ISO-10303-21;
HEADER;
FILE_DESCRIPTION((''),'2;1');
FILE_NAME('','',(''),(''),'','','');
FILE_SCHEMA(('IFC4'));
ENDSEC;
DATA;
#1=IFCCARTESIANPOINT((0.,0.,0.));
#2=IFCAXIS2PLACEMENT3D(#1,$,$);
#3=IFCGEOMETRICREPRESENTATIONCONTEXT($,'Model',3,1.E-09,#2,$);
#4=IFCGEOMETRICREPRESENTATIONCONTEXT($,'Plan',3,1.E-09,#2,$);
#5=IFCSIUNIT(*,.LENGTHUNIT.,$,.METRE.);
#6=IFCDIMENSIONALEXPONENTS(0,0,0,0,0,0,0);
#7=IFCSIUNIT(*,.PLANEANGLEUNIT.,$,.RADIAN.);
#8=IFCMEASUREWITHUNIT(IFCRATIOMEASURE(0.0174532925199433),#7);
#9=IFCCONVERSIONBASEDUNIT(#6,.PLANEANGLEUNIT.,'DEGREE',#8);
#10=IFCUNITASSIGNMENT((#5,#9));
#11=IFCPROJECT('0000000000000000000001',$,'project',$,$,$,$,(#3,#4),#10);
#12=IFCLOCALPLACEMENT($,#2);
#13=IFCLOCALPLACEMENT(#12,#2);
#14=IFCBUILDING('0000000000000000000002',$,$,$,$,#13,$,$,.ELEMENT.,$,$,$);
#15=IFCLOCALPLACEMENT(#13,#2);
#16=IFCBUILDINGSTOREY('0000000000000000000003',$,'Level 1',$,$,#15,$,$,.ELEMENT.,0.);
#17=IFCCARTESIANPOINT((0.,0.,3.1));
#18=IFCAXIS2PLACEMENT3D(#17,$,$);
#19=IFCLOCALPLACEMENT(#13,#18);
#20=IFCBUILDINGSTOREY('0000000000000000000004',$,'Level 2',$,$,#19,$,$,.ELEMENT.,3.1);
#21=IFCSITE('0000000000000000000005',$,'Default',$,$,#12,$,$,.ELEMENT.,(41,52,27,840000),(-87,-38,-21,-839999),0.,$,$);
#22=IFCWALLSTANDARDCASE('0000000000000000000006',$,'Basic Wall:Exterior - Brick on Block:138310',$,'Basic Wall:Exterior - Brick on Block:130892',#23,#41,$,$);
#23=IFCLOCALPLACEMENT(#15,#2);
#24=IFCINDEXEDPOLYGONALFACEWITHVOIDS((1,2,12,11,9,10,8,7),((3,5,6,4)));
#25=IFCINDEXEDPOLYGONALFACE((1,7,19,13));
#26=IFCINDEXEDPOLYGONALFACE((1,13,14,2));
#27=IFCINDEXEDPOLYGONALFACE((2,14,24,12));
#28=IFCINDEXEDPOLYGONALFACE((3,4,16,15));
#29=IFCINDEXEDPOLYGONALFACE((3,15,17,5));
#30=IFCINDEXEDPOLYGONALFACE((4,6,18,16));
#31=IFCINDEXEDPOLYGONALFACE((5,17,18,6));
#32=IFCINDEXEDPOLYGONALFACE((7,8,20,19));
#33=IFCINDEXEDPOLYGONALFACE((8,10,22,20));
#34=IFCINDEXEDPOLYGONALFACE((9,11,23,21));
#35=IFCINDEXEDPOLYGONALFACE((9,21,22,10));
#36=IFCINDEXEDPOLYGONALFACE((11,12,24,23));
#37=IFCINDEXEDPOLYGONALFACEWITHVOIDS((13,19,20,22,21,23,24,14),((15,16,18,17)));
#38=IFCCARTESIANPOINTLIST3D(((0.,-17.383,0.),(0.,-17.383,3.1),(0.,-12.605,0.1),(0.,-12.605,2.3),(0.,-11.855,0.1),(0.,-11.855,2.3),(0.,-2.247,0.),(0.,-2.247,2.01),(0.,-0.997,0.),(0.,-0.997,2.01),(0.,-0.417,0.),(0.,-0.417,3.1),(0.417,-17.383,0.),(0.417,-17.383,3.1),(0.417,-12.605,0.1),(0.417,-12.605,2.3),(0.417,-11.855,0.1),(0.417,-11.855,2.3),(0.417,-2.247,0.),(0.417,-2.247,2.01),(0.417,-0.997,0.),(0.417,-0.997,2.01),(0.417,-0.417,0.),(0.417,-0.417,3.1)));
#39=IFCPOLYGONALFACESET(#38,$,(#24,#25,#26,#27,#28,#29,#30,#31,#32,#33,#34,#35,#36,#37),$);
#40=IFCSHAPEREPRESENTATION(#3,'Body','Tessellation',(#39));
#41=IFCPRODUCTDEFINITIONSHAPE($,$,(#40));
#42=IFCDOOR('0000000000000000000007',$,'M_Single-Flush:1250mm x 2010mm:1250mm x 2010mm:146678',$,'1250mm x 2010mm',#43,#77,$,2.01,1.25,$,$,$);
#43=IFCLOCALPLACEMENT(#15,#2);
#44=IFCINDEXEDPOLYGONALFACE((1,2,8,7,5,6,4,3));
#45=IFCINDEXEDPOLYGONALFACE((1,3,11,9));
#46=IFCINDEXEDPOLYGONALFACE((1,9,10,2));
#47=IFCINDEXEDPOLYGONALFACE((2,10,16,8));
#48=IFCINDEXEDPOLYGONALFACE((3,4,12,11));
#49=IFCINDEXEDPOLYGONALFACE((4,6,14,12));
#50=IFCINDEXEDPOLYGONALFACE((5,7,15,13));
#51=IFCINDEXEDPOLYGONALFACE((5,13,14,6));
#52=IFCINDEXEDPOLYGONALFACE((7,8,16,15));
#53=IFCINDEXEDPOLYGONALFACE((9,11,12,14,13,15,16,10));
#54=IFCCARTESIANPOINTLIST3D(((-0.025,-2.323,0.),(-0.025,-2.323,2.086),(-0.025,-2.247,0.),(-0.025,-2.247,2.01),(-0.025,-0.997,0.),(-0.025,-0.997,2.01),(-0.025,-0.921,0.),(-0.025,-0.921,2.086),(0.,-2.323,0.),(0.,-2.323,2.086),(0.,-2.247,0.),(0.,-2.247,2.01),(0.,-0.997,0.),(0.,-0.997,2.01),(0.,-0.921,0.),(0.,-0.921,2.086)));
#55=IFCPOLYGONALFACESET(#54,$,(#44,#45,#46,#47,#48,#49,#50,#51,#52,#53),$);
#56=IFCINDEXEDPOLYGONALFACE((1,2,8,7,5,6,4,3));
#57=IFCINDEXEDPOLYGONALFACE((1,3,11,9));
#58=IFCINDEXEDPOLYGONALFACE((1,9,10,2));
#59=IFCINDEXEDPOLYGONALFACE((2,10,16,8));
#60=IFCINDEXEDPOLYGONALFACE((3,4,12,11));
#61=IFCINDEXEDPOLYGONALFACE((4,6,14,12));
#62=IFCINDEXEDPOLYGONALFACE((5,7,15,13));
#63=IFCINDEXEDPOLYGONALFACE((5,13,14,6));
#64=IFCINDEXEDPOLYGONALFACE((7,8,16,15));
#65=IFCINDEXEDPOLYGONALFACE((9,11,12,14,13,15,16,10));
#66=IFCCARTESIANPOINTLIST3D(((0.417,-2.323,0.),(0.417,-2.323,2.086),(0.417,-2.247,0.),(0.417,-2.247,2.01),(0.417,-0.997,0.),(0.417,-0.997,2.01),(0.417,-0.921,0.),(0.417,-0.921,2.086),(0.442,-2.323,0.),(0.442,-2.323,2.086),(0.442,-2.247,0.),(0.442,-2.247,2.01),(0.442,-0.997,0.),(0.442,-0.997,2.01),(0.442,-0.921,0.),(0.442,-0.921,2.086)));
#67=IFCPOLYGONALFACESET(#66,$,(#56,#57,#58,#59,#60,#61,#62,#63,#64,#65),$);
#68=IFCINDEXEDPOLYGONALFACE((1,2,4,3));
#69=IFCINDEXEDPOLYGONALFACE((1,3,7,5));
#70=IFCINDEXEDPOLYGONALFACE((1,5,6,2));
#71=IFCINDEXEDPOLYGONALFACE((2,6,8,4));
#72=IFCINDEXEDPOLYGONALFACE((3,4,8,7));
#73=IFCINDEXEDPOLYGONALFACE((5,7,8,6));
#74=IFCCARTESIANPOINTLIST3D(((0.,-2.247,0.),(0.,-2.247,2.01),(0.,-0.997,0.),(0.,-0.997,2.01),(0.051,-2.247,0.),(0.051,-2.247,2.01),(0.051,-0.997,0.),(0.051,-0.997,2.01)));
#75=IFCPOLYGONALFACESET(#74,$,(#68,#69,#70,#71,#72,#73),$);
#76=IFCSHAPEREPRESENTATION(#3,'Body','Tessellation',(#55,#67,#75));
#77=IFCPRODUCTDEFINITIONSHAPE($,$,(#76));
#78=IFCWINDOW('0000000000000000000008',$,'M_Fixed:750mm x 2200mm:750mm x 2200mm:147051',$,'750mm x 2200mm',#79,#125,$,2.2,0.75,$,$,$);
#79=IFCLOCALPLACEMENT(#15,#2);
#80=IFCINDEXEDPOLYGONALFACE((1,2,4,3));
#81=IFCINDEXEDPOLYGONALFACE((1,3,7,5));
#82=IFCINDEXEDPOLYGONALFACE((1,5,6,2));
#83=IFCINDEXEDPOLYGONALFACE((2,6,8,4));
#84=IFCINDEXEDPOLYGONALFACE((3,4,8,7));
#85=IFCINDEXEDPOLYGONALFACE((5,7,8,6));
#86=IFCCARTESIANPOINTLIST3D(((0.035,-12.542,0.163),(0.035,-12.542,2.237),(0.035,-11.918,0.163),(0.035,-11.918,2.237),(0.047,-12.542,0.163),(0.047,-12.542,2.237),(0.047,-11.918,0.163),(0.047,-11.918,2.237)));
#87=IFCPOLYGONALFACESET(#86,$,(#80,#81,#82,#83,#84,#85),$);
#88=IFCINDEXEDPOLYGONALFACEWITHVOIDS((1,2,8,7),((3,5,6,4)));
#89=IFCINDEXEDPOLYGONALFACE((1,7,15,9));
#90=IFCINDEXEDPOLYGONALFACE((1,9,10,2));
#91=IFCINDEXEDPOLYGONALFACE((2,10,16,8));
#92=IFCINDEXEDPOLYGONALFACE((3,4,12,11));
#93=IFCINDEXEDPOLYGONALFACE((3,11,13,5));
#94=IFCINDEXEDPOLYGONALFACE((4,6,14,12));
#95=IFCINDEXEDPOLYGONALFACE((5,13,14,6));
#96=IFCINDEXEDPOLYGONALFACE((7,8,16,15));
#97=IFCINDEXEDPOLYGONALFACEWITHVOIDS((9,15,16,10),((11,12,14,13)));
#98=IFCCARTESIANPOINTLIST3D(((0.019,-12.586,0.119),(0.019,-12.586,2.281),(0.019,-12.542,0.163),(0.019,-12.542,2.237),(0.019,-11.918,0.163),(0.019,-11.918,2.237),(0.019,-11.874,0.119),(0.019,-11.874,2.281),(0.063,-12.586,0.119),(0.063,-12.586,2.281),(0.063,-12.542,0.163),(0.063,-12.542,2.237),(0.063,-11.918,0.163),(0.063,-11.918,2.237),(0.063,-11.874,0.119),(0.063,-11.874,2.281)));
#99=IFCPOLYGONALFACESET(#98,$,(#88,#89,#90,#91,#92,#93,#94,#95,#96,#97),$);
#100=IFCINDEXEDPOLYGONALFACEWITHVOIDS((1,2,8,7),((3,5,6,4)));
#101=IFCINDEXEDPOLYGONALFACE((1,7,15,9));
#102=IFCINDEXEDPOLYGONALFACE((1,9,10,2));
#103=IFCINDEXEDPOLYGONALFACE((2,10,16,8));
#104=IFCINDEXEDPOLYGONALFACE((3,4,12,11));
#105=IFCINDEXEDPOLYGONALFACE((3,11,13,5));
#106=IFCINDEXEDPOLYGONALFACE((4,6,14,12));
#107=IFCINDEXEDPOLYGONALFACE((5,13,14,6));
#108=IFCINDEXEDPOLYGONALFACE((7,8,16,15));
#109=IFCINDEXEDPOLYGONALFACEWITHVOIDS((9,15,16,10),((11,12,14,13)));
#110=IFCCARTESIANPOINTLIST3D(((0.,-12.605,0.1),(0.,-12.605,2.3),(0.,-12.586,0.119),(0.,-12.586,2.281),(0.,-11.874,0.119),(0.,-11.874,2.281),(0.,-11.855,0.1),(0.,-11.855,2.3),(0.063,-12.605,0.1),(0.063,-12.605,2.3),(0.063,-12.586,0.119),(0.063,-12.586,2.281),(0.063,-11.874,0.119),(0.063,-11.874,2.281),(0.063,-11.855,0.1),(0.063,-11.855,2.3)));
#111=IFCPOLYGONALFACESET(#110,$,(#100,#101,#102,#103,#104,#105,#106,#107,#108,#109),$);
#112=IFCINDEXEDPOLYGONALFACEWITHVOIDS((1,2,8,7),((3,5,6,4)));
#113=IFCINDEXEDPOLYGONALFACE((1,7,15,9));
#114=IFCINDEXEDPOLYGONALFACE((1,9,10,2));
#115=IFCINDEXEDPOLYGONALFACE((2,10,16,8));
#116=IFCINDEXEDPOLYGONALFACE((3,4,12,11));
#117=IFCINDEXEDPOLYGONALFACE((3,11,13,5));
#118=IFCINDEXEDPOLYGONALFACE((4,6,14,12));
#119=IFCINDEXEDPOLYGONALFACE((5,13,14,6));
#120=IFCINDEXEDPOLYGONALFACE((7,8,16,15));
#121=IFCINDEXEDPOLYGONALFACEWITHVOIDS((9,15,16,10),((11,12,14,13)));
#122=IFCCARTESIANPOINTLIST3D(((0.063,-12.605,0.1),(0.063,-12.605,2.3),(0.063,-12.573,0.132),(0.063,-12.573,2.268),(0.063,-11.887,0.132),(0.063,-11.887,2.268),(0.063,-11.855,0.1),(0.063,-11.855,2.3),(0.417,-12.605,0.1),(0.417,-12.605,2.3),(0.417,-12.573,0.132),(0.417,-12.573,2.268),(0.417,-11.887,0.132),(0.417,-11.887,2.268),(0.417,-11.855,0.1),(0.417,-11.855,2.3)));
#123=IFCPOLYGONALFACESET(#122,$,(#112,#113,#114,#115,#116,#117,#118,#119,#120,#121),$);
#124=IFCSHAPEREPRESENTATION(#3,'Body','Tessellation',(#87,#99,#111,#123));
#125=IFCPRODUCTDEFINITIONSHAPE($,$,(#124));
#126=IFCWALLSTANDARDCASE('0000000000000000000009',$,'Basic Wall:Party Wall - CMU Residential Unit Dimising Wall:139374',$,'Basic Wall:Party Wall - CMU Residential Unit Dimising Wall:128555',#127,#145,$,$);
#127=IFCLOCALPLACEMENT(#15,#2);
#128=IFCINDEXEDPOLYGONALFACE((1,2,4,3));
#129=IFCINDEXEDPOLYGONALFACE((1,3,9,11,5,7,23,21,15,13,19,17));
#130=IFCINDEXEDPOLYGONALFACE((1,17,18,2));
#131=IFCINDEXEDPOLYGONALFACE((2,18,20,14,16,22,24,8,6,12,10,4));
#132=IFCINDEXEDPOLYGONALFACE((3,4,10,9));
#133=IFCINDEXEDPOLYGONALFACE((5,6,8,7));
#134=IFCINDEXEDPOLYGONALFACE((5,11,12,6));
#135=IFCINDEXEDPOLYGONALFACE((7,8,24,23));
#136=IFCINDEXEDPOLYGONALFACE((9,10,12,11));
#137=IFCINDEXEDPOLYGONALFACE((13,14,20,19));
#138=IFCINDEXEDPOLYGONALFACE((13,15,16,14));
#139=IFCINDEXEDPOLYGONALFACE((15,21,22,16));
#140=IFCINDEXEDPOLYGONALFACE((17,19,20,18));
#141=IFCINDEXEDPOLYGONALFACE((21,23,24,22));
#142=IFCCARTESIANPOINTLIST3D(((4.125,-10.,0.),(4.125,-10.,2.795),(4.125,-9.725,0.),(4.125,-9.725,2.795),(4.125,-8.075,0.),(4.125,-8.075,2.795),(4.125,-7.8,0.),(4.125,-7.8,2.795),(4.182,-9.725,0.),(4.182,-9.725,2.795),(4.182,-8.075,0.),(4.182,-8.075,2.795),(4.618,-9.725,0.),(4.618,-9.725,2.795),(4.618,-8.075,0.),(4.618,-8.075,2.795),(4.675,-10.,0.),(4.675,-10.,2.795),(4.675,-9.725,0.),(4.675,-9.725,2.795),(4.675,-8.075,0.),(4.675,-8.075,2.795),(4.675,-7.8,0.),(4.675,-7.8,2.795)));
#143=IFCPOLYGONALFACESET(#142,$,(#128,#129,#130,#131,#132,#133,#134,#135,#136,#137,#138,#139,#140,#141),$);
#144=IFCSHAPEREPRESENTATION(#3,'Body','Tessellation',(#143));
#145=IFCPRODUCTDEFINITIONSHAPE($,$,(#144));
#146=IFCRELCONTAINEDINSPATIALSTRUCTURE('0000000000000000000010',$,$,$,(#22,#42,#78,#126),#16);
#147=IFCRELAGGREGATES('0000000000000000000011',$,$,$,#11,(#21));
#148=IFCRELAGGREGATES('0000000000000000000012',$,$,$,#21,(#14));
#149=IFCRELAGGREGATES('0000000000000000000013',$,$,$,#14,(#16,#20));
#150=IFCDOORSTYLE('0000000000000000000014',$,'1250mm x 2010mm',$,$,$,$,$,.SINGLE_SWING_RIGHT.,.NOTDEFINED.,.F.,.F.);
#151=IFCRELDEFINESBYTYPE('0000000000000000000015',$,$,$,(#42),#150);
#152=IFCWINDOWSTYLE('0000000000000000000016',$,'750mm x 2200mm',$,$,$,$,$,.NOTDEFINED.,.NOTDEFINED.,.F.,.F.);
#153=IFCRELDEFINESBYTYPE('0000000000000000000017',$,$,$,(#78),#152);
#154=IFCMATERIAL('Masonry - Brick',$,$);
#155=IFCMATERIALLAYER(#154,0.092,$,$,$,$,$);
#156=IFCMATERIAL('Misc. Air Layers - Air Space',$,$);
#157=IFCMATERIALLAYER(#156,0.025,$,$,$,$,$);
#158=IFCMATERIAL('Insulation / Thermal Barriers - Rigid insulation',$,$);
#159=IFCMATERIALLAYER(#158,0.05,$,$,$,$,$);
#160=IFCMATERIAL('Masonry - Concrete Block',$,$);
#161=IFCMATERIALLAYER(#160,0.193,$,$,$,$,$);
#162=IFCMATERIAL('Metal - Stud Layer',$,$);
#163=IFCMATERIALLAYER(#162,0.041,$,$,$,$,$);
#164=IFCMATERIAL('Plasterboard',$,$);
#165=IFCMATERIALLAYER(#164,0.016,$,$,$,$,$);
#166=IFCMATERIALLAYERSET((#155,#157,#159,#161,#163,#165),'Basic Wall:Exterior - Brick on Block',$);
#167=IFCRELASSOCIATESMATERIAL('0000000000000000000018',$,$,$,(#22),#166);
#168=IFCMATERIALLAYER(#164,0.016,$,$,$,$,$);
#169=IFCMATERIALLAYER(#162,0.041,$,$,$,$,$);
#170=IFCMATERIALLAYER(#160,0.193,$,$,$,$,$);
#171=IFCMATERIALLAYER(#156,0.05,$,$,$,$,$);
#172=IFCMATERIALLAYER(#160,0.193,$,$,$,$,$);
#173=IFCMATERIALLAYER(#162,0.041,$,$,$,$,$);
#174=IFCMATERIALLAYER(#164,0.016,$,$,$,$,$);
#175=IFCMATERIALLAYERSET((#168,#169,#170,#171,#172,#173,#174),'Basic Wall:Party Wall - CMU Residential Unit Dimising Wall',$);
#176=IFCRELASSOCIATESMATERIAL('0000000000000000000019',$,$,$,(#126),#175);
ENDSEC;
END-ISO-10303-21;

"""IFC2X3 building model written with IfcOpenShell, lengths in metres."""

from ifc_helpers import new_model, entity, si_unit, converted_unit, frame, frame_2d, origin, origin_2d_with_axis, place, context, project, spatial, polyline, rectangle, outline, extrude, clip, bounded_halfspace, source, transform, mapped, material, layer, layer_set, layer_usage, type_object, type_shapes, element, fill, save


model = new_model("IFC2X3")

# Units and contexts
model_context = context("Model", 3, precision=1e-09, world=origin())
plan_context = context("Plan", 3, precision=1e-09, world=origin())
ifc_project = project(units=[si_unit("LENGTHUNIT", "METRE"), converted_unit("PLANEANGLEUNIT", "DEGREE", entity("IfcRatioMeasure", 0.0174532925199433), si_unit("PLANEANGLEUNIT", "RADIAN"), dimensions=[0, 0, 0, 0, 0, 0, 0])], contexts=[model_context, plan_context])

# Site, building, storey
site_placement = place(None, origin())
site = spatial("IfcSite", under=ifc_project, at=site_placement, Name="Default", CompositionType="ELEMENT", RefLatitude=(41, 52, 27, 840000), RefLongitude=(-87, -38, -21, -839999), RefElevation=0.0)
building_placement = place(site_placement, origin())
building = spatial("IfcBuilding", under=site, at=building_placement, CompositionType="ELEMENT")
storey_1_placement = place(building_placement, origin())
storey_1 = spatial("IfcBuildingStorey", under=building, at=storey_1_placement, Name="Level 1", CompositionType="ELEMENT", Elevation=0.0)

# Shared definitions
ifc_material_1 = material(Name="Masonry - Brick")
ifc_layer_1 = layer(ifc_material_1, 0.092)
ifc_material_2 = material(Name="Misc. Air Layers - Air Space")
ifc_layer_2 = layer(ifc_material_2, 0.025)
ifc_material_3 = material(Name="Insulation / Thermal Barriers - Rigid insulation")
ifc_layer_3 = layer(ifc_material_3, 0.05)
ifc_material_4 = material(Name="Masonry - Concrete Block")
ifc_layer_4 = layer(ifc_material_4, 0.193)
ifc_material_5 = material(Name="Metal - Stud Layer")
ifc_layer_5 = layer(ifc_material_5, 0.041)
ifc_material_6 = material(Name="Plasterboard")
ifc_layer_6 = layer(ifc_material_6, 0.016)
ifc_layer_set_1 = layer_set([ifc_layer_1, ifc_layer_2, ifc_layer_3, ifc_layer_4, ifc_layer_5, ifc_layer_6], Name="Basic Wall:Exterior - Brick on Block")

# Wall, openings, door, window
ifc_layer_usage_1 = layer_usage(ifc_layer_set_1, "AXIS2", "NEGATIVE", 0.2085)
wall_1_placement = place(storey_1_placement, frame((0.2085, -17.383, 0.0), z_axis=(0.0, 0.0, 1.0), x_axis=(0.0, 1.0, 0.0)))
wall_1 = element("IfcWallStandardCase", 1, at=wall_1_placement, inside=storey_1, material=ifc_layer_usage_1, Name="Basic Wall:Exterior - Brick on Block:138310", ObjectType="Basic Wall:Exterior - Brick on Block:130892", context=model_context, shape_type="SweptSolid", body=[
    extrude(rectangle(XDim=16.966, YDim=0.417, at=frame_2d((8.483, 0.0), x_axis=(-1.0, 0.0))), origin(), (0.0, 0.0, 1.0), 3.1),
])
opening_1_placement = place(wall_1_placement, frame((15.136, -0.2085, 0.0)))
opening_1 = element("IfcOpeningElement", 2, at=opening_1_placement, cuts=wall_1, ObjectType="Opening", context=model_context, shape_type="SweptSolid", body=[
    extrude(rectangle(XDim=1.25, YDim=2.01, at=frame_2d((1.005, 0.625), x_axis=(0.0, 1.0))), frame((0.0, 0.0, 0.0), z_axis=(0.0, 1.0, 0.0), x_axis=(0.0, 0.0, 1.0)), (0.0, 0.0, 1.0), 0.417),
])
opening_2_placement = place(wall_1_placement, frame((4.778, -0.2085, 0.1)))
opening_2 = element("IfcOpeningElement", 3, at=opening_2_placement, cuts=wall_1, ObjectType="Opening", context=model_context, shape_type="SweptSolid", body=[
    extrude(rectangle(XDim=2.2, YDim=0.75, at=frame_2d((1.1, 0.375), x_axis=(1.0, 0.0))), frame((0.0, 0.0, 0.0), z_axis=(0.0, 1.0, 0.0), x_axis=(0.0, 0.0, 1.0)), (0.0, 0.0, 1.0), 0.417),
])
door_style_1 = type_object("IfcDoorStyle", Name="1250mm x 2010mm", ConstructionType="NOTDEFINED", OperationType="SINGLE_SWING_RIGHT", ParameterTakesPrecedence=False, Sizeable=False)
shared_shape_1 = source(origin(), model_context, "Body", "SweptSolid", [
    extrude(outline(polyline([(-0.701, -1.062), (0.701, -1.062), (0.701, 1.024), (0.625, 1.024), (0.625, -0.986), (-0.625, -0.986), (-0.625, 1.024), (-0.701, 1.024), (-0.701, -1.062)])), frame((0.625, 0.417, 1.024), z_axis=(0.0, 1.0, 0.0), x_axis=(1.0, 0.0, 0.0)), (0.0, 0.0, 1.0), 0.025),
    extrude(outline(polyline([(-1.062, -0.701), (1.024, -0.701), (1.024, -0.625), (-0.986, -0.625), (-0.986, 0.625), (1.024, 0.625), (1.024, 0.701), (-1.062, 0.701), (-1.062, -0.701)])), frame((0.625, -0.025, 1.024), z_axis=(0.0, 1.0, 0.0), x_axis=(0.0, 0.0, -1.0)), (0.0, 0.0, 1.0), 0.025),
    extrude(rectangle(XDim=0.051, YDim=1.25, at=origin_2d_with_axis()), frame((0.625, 0.3915, 0.0), z_axis=(0.0, 0.0, 1.0), x_axis=(0.0, 1.0, 0.0)), (0.0, 0.0, 1.0), 2.01),
])
type_shapes(door_style_1, [shared_shape_1])
door_1_placement = place(opening_1_placement, origin())
door_1 = element("IfcDoor", 4, at=door_1_placement, inside=storey_1, type_object=door_style_1, Name="M_Single-Flush:1250mm x 2010mm:1250mm x 2010mm:146678", ObjectType="1250mm x 2010mm", OverallHeight=2.01, OverallWidth=1.25, context=model_context, shape_type="MappedRepresentation", body=[
    mapped(shared_shape_1, transform((0.0, 0.0, 0.0), scale=1.0)),
])
fill(opening_1, door_1)
window_style_1 = type_object("IfcWindowStyle", Name="750mm x 2200mm", ConstructionType="NOTDEFINED", OperationType="NOTDEFINED", ParameterTakesPrecedence=False, Sizeable=False)
shared_shape_2 = source(origin(), model_context, "Body", "SweptSolid", [
    extrude(rectangle(XDim=0.012, YDim=0.624, at=origin_2d_with_axis()), frame((0.375, 0.376, 0.063), z_axis=(0.0, 0.0, 1.0), x_axis=(0.0, -1.0, 0.0)), (0.0, 0.0, 1.0), 2.074),
    extrude(outline(polyline([(-0.356, -1.081), (0.356, -1.081), (0.356, 1.081), (-0.356, 1.081), (-0.356, -1.081)]), holes=[polyline([(-0.312, -1.037), (-0.312, 1.037), (0.312, 1.037), (0.312, -1.037), (-0.312, -1.037)])]), frame((0.375, 0.354, 1.1), z_axis=(0.0, 1.0, 0.0), x_axis=(1.0, 0.0, 0.0)), (0.0, 0.0, 1.0), 0.044),
    extrude(outline(polyline([(-0.375, -1.1), (0.375, -1.1), (0.375, 1.1), (-0.375, 1.1), (-0.375, -1.1)]), holes=[polyline([(-0.356, -1.081), (-0.356, 1.081), (0.356, 1.081), (0.356, -1.081), (-0.356, -1.081)])]), frame((0.375, 0.354, 1.1), z_axis=(0.0, 1.0, 0.0), x_axis=(1.0, 0.0, 0.0)), (0.0, 0.0, 1.0), 0.063),
    extrude(outline(polyline([(-0.375, -1.1), (0.375, -1.1), (0.375, 1.1), (-0.375, 1.1), (-0.375, -1.1)]), holes=[polyline([(-0.343, -1.068), (-0.343, 1.068), (0.343, 1.068), (0.343, -1.068), (-0.343, -1.068)])]), frame((0.375, 0.0, 1.1), z_axis=(0.0, 1.0, 0.0), x_axis=(1.0, 0.0, 0.0)), (0.0, 0.0, 1.0), 0.354),
])
type_shapes(window_style_1, [shared_shape_2])
window_1_placement = place(opening_2_placement, origin())
window_1 = element("IfcWindow", 5, at=window_1_placement, inside=storey_1, type_object=window_style_1, Name="M_Fixed:750mm x 2200mm:750mm x 2200mm:147051", ObjectType="750mm x 2200mm", OverallHeight=2.2, OverallWidth=0.75, context=model_context, shape_type="MappedRepresentation", body=[
    mapped(shared_shape_2, transform((0.0, 0.0, 0.0), scale=1.0)),
])
fill(opening_2, window_1)

# Wall
ifc_layer_7 = layer(ifc_material_6, 0.016)
ifc_layer_8 = layer(ifc_material_5, 0.041)
ifc_layer_9 = layer(ifc_material_4, 0.193)
ifc_layer_10 = layer(ifc_material_2, 0.05)
ifc_layer_11 = layer(ifc_material_4, 0.193)
ifc_layer_12 = layer(ifc_material_5, 0.041)
ifc_layer_13 = layer(ifc_material_6, 0.016)
ifc_layer_set_2 = layer_set([ifc_layer_7, ifc_layer_8, ifc_layer_9, ifc_layer_10, ifc_layer_11, ifc_layer_12, ifc_layer_13], Name="Basic Wall:Party Wall - CMU Residential Unit Dimising Wall")
ifc_layer_usage_2 = layer_usage(ifc_layer_set_2, "AXIS2", "NEGATIVE", 0.275)
wall_2_placement = place(storey_1_placement, frame((4.4, -10.0, 0.0), z_axis=(0.0, 0.0, 1.0), x_axis=(0.0, 1.0, 0.0)))
element("IfcWallStandardCase", 6, at=wall_2_placement, inside=storey_1, material=ifc_layer_usage_2, Name="Basic Wall:Party Wall - CMU Residential Unit Dimising Wall:139374", ObjectType="Basic Wall:Party Wall - CMU Residential Unit Dimising Wall:128555", context=model_context, shape_type="Clipping", body=[
    clip(clip(extrude(rectangle(XDim=2.2, YDim=0.55, at=frame_2d((1.1, 0.0), x_axis=(-1.0, 0.0))), origin(), (0.0, 0.0, 1.0), 2.795), bounded_halfspace(frame((1.925, 0.218, 0.0), z_axis=(0.0, -1.0, 0.0), x_axis=(1.0, 0.0, 0.0)), True, frame((1.925, 0.218, 0.0), z_axis=(0.0, -1.0, 0.0), x_axis=(1.0, 0.0, 0.0)), polyline([(0.0, 0.0), (0.0, 2.795), (-1.65, 2.795), (-1.65, 0.0), (0.0, 0.0)]))), bounded_halfspace(frame((0.275, -0.218, 0.0), z_axis=(0.0, 1.0, 0.0), x_axis=(-1.0, 0.0, 0.0)), True, frame((0.275, -0.218, 0.0), z_axis=(0.0, 1.0, 0.0), x_axis=(-1.0, 0.0, 0.0)), polyline([(0.0, 0.0), (0.0, 2.795), (-1.65, 2.795), (-1.65, 0.0), (0.0, 0.0)]))),
])

# Shared definitions
storey_2_placement = place(building_placement, frame((0.0, 0.0, 3.1)))
storey_2 = spatial("IfcBuildingStorey", under=building, at=storey_2_placement, Name="Level 2", CompositionType="ELEMENT", Elevation=3.1)

save(model, "model.ifc")
